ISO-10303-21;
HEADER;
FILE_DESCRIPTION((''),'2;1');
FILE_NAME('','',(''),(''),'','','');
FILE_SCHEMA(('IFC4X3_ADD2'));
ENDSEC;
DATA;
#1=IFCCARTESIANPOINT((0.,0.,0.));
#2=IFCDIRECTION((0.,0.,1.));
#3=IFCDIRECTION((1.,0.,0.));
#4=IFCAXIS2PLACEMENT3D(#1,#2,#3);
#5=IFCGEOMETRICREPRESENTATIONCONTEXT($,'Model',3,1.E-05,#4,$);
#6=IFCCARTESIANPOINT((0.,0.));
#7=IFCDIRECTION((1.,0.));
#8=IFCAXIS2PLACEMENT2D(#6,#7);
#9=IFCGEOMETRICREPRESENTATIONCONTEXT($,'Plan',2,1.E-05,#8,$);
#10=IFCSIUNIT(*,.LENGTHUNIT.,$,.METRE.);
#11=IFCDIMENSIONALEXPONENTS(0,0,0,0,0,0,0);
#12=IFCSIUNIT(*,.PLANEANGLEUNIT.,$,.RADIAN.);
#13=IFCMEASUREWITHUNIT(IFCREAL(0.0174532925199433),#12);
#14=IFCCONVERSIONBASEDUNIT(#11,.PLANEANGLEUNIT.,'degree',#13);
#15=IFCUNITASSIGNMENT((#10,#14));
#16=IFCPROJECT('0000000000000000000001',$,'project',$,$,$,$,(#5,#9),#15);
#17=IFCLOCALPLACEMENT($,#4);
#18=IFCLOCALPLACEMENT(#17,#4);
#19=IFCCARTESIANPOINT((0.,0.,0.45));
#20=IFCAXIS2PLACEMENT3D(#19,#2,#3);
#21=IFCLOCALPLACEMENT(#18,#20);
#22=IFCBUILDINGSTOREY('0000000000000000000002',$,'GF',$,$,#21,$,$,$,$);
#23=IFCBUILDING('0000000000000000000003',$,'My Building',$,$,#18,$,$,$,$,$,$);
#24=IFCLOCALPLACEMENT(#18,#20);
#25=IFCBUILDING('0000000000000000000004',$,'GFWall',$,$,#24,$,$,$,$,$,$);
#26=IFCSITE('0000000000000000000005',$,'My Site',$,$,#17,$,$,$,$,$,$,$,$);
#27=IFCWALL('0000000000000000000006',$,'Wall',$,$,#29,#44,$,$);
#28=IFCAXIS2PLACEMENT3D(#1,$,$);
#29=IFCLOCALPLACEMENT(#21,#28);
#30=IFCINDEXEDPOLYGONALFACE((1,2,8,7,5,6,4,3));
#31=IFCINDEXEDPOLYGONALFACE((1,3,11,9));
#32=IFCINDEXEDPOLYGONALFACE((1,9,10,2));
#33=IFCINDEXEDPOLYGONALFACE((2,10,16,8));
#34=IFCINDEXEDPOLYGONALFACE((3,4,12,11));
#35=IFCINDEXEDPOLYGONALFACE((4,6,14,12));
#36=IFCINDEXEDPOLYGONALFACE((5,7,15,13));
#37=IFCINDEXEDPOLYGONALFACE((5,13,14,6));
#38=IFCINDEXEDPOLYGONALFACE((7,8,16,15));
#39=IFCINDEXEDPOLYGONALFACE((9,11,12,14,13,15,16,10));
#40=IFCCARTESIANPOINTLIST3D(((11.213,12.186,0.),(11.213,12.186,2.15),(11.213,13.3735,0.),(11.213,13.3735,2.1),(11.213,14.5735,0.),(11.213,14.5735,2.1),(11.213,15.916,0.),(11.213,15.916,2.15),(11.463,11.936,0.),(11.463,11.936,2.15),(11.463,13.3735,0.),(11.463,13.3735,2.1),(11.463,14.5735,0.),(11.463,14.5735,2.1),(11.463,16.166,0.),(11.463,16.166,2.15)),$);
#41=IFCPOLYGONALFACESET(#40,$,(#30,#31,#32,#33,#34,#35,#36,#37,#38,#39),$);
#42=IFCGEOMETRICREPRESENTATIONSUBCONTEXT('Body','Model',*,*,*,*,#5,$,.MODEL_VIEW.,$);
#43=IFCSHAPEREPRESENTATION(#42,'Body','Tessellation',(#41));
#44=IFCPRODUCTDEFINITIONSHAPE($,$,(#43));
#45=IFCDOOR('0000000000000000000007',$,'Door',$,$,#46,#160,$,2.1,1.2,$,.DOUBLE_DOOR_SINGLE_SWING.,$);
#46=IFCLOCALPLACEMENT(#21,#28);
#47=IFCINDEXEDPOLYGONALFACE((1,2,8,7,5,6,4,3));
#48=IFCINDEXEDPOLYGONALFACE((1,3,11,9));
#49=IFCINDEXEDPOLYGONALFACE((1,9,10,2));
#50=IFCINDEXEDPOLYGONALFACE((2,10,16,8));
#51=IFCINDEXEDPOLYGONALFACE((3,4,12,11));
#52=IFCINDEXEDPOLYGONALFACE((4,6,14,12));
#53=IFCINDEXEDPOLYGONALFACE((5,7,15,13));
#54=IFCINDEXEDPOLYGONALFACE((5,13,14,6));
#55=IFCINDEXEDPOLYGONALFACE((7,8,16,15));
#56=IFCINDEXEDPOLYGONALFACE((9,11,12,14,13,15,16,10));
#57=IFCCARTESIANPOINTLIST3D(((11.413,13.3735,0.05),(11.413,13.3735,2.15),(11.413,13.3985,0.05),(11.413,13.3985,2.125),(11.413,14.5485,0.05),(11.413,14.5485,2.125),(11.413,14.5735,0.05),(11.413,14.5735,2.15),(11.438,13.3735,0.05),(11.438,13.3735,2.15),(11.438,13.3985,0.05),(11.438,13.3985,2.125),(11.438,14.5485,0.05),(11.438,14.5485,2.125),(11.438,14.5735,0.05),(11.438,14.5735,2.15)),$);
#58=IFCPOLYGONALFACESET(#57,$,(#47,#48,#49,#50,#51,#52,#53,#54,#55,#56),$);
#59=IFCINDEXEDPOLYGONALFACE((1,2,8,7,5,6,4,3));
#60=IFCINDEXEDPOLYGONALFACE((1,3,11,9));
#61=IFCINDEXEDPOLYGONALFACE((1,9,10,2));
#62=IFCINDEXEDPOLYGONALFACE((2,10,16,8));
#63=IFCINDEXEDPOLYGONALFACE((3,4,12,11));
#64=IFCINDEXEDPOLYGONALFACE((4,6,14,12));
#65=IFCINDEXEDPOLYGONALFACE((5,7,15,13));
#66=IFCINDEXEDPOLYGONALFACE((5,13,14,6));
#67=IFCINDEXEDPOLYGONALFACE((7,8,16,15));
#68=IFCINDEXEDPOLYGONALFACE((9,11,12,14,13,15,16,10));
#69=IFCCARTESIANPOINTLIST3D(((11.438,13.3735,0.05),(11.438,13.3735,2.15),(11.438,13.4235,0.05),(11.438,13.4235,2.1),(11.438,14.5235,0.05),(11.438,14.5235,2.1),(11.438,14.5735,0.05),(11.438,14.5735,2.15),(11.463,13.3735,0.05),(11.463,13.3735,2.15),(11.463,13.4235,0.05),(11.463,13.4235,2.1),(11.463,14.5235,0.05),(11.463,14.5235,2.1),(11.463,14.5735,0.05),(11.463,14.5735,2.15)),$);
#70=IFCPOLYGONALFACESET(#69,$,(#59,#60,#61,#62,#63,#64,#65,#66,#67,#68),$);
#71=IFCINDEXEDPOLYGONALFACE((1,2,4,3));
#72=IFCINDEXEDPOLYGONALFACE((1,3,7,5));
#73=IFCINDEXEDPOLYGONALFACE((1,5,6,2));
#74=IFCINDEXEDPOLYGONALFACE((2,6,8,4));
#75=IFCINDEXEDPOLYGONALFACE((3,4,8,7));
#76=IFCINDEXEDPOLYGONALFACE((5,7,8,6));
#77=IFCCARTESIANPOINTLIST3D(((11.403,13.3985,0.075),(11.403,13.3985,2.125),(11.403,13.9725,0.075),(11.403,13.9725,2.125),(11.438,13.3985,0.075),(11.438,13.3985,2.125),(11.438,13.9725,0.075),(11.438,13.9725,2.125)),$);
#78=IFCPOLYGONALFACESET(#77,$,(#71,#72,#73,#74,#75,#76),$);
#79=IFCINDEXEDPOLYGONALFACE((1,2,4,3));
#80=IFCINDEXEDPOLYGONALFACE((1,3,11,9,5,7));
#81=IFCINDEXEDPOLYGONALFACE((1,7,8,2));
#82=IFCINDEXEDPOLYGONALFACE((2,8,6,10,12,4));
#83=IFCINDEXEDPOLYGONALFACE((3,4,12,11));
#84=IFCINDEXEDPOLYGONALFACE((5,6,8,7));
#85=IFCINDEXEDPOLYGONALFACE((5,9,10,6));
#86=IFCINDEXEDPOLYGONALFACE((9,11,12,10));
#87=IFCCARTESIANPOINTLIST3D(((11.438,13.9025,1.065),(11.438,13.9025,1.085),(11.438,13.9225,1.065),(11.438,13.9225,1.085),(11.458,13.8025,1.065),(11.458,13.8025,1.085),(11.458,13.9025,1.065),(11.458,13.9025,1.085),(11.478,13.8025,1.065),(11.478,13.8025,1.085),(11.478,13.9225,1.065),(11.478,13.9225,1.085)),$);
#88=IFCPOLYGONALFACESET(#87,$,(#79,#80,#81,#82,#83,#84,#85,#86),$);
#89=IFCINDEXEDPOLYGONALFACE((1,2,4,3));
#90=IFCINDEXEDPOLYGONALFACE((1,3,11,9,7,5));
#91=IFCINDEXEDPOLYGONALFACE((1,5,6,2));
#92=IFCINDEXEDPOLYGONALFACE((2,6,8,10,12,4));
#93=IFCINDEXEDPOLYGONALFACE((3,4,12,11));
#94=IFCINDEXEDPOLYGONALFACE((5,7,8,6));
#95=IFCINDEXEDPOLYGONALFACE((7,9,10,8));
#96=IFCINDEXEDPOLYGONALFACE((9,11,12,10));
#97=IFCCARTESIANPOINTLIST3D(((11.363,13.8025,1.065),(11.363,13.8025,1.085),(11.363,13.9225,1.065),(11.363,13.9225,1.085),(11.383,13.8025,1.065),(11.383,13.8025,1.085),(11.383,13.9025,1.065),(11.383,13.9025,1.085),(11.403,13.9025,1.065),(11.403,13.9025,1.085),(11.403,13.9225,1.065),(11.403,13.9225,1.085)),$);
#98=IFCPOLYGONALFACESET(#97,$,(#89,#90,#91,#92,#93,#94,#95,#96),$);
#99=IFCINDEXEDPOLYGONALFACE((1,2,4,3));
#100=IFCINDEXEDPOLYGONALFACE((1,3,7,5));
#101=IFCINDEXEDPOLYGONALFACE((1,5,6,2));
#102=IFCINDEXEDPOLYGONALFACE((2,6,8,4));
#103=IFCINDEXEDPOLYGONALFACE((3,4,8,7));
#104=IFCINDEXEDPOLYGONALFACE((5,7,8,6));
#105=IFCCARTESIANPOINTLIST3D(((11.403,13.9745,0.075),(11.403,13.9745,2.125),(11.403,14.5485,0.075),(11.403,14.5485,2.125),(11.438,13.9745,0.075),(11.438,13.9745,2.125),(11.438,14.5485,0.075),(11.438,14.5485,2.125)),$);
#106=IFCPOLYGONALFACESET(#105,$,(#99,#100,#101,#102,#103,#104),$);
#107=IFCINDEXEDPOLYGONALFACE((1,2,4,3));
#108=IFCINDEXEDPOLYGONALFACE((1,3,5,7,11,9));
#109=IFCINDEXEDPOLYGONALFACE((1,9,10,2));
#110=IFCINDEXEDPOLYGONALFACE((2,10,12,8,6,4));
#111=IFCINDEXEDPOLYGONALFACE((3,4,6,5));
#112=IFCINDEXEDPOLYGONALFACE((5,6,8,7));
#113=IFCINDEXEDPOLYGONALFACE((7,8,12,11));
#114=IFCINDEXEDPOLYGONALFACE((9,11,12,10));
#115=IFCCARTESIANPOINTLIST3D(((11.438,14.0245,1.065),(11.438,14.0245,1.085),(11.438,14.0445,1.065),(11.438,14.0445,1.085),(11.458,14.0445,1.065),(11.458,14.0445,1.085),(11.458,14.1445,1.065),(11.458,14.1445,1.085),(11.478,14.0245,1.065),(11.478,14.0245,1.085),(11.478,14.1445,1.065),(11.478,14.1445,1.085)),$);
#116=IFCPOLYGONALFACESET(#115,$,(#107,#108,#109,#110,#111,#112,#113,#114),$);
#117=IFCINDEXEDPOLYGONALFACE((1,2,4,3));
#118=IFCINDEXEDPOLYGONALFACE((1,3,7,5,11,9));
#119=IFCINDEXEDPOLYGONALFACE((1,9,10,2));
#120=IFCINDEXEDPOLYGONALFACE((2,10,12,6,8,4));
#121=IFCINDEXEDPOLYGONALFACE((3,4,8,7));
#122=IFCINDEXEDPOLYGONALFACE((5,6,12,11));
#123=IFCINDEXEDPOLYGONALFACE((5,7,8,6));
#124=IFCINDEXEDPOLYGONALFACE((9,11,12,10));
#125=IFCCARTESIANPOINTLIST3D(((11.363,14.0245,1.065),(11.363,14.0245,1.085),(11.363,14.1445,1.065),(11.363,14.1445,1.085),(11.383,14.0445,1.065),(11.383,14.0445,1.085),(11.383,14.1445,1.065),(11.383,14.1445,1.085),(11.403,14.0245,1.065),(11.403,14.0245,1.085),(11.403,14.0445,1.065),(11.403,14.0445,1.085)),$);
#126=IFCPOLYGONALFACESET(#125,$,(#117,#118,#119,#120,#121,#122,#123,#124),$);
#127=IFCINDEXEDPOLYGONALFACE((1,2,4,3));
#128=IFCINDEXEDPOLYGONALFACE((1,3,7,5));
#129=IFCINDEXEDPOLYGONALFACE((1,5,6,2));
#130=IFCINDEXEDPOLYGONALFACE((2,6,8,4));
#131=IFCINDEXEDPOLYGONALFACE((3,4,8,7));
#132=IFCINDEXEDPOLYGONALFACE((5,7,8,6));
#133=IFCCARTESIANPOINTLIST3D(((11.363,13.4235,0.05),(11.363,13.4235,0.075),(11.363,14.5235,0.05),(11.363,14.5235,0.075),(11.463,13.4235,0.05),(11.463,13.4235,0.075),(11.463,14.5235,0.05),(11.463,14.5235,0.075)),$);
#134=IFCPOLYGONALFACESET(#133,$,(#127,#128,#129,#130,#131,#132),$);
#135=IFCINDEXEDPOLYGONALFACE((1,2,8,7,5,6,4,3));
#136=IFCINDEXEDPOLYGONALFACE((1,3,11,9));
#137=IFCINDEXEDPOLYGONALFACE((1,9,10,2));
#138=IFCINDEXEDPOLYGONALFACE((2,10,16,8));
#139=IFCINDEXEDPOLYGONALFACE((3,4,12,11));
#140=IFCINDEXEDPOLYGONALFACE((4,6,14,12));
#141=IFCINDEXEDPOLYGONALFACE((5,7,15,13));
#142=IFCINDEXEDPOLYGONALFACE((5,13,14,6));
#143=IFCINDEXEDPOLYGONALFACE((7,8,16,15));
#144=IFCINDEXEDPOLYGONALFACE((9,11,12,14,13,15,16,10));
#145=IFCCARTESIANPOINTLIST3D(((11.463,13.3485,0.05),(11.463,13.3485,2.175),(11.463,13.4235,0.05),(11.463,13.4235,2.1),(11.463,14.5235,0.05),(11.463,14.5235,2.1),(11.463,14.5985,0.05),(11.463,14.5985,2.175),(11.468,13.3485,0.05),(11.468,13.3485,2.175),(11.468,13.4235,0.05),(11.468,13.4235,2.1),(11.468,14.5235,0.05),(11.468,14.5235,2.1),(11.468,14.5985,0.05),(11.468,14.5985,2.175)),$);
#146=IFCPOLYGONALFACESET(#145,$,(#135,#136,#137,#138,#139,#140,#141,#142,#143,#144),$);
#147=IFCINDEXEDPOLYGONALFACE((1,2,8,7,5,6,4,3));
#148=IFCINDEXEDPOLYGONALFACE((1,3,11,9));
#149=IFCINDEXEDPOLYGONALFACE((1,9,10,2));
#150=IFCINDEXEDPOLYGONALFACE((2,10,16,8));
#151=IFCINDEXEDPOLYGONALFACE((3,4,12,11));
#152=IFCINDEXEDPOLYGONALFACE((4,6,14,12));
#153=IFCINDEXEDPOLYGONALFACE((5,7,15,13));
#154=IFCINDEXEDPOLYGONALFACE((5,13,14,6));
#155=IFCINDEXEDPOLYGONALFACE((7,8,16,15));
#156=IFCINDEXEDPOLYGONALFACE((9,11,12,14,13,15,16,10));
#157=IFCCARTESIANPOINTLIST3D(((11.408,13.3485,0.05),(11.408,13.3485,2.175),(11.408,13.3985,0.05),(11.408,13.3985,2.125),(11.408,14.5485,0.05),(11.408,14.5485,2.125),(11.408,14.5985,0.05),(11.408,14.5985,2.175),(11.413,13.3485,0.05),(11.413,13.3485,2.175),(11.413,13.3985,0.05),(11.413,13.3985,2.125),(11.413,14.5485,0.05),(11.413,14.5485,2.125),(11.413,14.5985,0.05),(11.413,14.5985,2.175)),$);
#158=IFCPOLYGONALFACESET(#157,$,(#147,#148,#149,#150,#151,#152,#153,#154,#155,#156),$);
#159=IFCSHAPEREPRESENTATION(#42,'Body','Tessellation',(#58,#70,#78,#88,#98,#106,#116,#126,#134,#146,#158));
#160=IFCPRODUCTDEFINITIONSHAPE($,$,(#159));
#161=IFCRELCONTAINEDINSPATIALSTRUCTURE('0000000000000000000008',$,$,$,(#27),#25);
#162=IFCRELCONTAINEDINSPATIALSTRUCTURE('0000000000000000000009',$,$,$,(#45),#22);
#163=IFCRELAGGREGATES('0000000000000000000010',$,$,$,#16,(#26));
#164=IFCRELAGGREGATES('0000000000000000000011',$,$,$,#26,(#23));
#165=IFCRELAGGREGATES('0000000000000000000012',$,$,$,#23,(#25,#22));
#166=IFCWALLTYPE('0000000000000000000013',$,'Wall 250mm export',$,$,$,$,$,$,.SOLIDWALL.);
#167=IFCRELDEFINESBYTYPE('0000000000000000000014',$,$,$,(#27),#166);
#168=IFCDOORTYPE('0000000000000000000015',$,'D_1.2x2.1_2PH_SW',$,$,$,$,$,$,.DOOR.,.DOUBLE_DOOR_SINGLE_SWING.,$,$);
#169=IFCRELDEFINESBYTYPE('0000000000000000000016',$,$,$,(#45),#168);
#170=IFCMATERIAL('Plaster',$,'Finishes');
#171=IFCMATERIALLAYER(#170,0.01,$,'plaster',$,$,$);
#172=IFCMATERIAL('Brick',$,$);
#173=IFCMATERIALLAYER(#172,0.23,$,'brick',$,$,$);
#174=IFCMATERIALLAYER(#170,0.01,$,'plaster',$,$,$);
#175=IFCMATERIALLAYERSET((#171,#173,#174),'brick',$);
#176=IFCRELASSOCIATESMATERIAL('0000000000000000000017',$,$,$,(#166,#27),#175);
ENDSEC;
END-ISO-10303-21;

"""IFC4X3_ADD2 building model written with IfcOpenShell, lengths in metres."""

from ifc_helpers import new_model, entity, si_unit, converted_unit, frame, origin_with_axes, origin_2d_with_axis, place, context, subcontext, project, spatial, line, indexed_curve, outline, extrude, shape, source, transform, mapped, material, layer, layer_set, layer_usage, type_object, type_shapes, element, fill, save


model = new_model("IFC4X3_ADD2")

# Units and contexts
model_context = context("Model", 3, precision=1e-05, world=origin_with_axes())
plan_context = context("Plan", 2, precision=1e-05, world=origin_2d_with_axis())
body_context_1 = subcontext(model_context, "Body", "Model", "MODEL_VIEW")
body_context_2 = subcontext(plan_context, "Body", "Plan", "PLAN_VIEW")
ifc_project = project(units=[si_unit("LENGTHUNIT", "METRE"), converted_unit("PLANEANGLEUNIT", "degree", entity("IfcReal", 0.0174532925199433), si_unit("PLANEANGLEUNIT", "RADIAN"), dimensions=[0, 0, 0, 0, 0, 0, 0])], contexts=[model_context, plan_context])

# Site, buildings
site_placement = place(None, origin_with_axes())
site = spatial("IfcSite", under=ifc_project, at=site_placement, Name="My Site")
building_1_placement = place(site_placement, origin_with_axes())
building_1 = spatial("IfcBuilding", under=site, at=building_1_placement, Name="My Building")
building_2_placement = place(building_1_placement, frame((0.0, 0.0, 0.45), z_axis=(0.0, 0.0, 1.0), x_axis=(1.0, 0.0, 0.0)))
building_2 = spatial("IfcBuilding", under=building_1, at=building_2_placement, Name="GFWall")

# Shared definitions
ifc_material_1 = material(Name="Plaster", Category="Finishes")
ifc_layer_1 = layer(ifc_material_1, 0.01, Name="plaster")
ifc_material_2 = material(Name="Brick")
ifc_layer_2 = layer(ifc_material_2, 0.23, Name="brick")
ifc_layer_3 = layer(ifc_material_1, 0.01, Name="plaster")
ifc_layer_set = layer_set([ifc_layer_1, ifc_layer_2, ifc_layer_3], Name="brick")
wall_type = type_object("IfcWallType", Name="Wall 250mm export", PredefinedType="SOLIDWALL", material=ifc_layer_set)

# Shared definitions
storey_placement = place(building_1_placement, frame((0.0, 0.0, 0.45), z_axis=(0.0, 0.0, 1.0), x_axis=(1.0, 0.0, 0.0)))
storey = spatial("IfcBuildingStorey", under=building_1, at=storey_placement, Name="GF")

# Wall, opening, door
ifc_layer_usage_1 = layer_usage(ifc_layer_set, "AXIS2", "POSITIVE", 0.0)
wall_1_placement = place(building_2_placement, frame((11.463, 11.936, 0.0), z_axis=(0.0, 0.0, 1.0), x_axis=(0.0, 1.0, 0.0)))
wall_1 = element("IfcWall", 1, at=wall_1_placement, inside=building_2, type_object=wall_type, material=ifc_layer_usage_1, Name="Wall", context=body_context_1, shape_type="SweptSolid", body=[
    extrude(outline(indexed_curve([(0.0, 0.0), (0.25, 0.25), (3.98, 0.25), (4.23, 0.0)], segments=[line(1, 2, 3, 4, 1)])), origin_with_axes(), (0.0, 0.0, 1.0), 2.15),
])
shared_shape_1 = source(origin_with_axes(), body_context_1, "Body", "SweptSolid", [
    extrude(outline(indexed_curve([(0.0, 0.0), (1.2, 0.0), (1.2, 2.1), (0.0, 2.1)], segments=[line(1, 2, 3, 4, 1)])), frame((0.0, -0.6, 0.0), z_axis=(0.0, -1.0, 0.0), x_axis=(1.0, 0.0, 0.0)), (0.0, 0.0, -1.0), 1.2),
])
opening_1_placement = place(wall_1_placement, frame((1.4375, 0.0, 0.0), z_axis=(0.0, 0.0, 1.0), x_axis=(1.0, 0.0, 0.0)))
opening_1 = element("IfcOpeningElement", 2, at=opening_1_placement, cuts=wall_1, PredefinedType="OPENING", context=body_context_1, shape_type="MappedRepresentation", body=[
    mapped(shared_shape_1, transform((0.0, 0.0, 0.0), x_axis=(1.0, 0.0, 0.0), y_axis=(0.0, 1.0, 0.0), z_axis=(0.0, 0.0, 1.0), scale=1.0)),
])
door_type_1 = type_object("IfcDoorType", Name="D_1.2x2.1_2PH_SW", OperationType="DOUBLE_DOOR_SINGLE_SWING", PredefinedType="DOOR")
shared_shape_2 = source(origin_with_axes(), body_context_1, "Body", "SweptSolid", [
    extrude(outline(indexed_curve([(0.0, 0.0), (0.0, 2.1), (1.2, 2.1), (1.2, 0.0), (1.175, 0.0), (1.175, 2.075), (0.025, 2.075), (0.025, 0.0)], segments=[line(1, 2, 3, 4, 5, 6, 7, 8, 1)])), frame((0.0, 0.025, 0.0), z_axis=(0.0, -1.0, 0.0), x_axis=(1.0, 0.0, 0.0)), (0.0, 0.0, -1.0), 0.025),
    extrude(outline(indexed_curve([(0.0, 0.0), (0.0, 2.1), (1.2, 2.1), (1.2, 0.0), (1.15, 0.0), (1.15, 2.05), (0.05, 2.05), (0.05, 0.0)], segments=[line(1, 2, 3, 4, 5, 6, 7, 8, 1)])), frame((0.0, 0.0, 0.0), z_axis=(0.0, -1.0, 0.0), x_axis=(1.0, 0.0, 0.0)), (0.0, 0.0, -1.0), 0.025),
    extrude(outline(indexed_curve([(0.0, 0.0), (0.574, 0.0), (0.574, 0.035), (0.0, 0.035)], segments=[line(1, 2, 3, 4, 1)])), frame((0.025, 0.025, 0.025), z_axis=(0.0, 0.0, 1.0), x_axis=(1.0, 0.0, 0.0)), (0.0, 0.0, 1.0), 2.05),
    extrude(outline(indexed_curve([(0.0, 0.0), (0.0, -0.04), (-0.12, -0.04), (-0.12, -0.02), (-0.02, -0.02), (-0.02, 0.0)], segments=[line(1, 2, 3, 4, 5, 6, 1)])), frame((0.549, 0.025, 1.015), z_axis=(0.0, 0.0, 1.0), x_axis=(1.0, 0.0, 0.0)), (0.0, 0.0, 1.0), 0.02),
    extrude(outline(indexed_curve([(0.0, 0.0), (0.0, 0.04), (-0.12, 0.04), (-0.12, 0.02), (-0.02, 0.02), (-0.02, 0.0)], segments=[line(1, 2, 3, 4, 5, 6, 1)])), frame((0.549, 0.06, 1.015), z_axis=(0.0, 0.0, 1.0), x_axis=(1.0, 0.0, 0.0)), (0.0, 0.0, 1.0), 0.02),
    extrude(outline(indexed_curve([(0.0, 0.0), (-0.574, 0.0), (-0.574, 0.035), (0.0, 0.035)], segments=[line(1, 2, 3, 4, 1)])), frame((1.175, 0.025, 0.025), z_axis=(0.0, 0.0, 1.0), x_axis=(1.0, 0.0, 0.0)), (0.0, 0.0, 1.0), 2.05),
    extrude(outline(indexed_curve([(0.0, 0.0), (0.0, -0.04), (0.12, -0.04), (0.12, -0.02), (0.02, -0.02), (0.02, 0.0)], segments=[line(1, 2, 3, 4, 5, 6, 1)])), frame((0.651, 0.025, 1.015), z_axis=(0.0, 0.0, 1.0), x_axis=(1.0, 0.0, 0.0)), (0.0, 0.0, 1.0), 0.02),
    extrude(outline(indexed_curve([(0.0, 0.0), (0.0, 0.04), (0.12, 0.04), (0.12, 0.02), (0.02, 0.02), (0.02, 0.0)], segments=[line(1, 2, 3, 4, 5, 6, 1)])), frame((0.651, 0.06, 1.015), z_axis=(0.0, 0.0, 1.0), x_axis=(1.0, 0.0, 0.0)), (0.0, 0.0, 1.0), 0.02),
    extrude(outline(indexed_curve([(0.0, 0.0), (1.1, 0.0), (1.1, 0.1), (0.0, 0.1)], segments=[line(1, 2, 3, 4, 1)])), frame((0.05, 0.0, 0.0), z_axis=(0.0, 0.0, 1.0), x_axis=(1.0, 0.0, 0.0)), (0.0, 0.0, 1.0), 0.025),
    extrude(outline(indexed_curve([(0.0, 0.0), (0.0, 2.125), (1.25, 2.125), (1.25, 0.0), (1.175, 0.0), (1.175, 2.05), (0.075, 2.05), (0.075, 0.0)], segments=[line(1, 2, 3, 4, 5, 6, 7, 8, 1)])), frame((-0.025, -0.005, 0.0), z_axis=(0.0, -1.0, 0.0), x_axis=(1.0, 0.0, 0.0)), (0.0, 0.0, -1.0), 0.005),
    extrude(outline(indexed_curve([(0.0, 0.0), (0.0, 2.125), (1.25, 2.125), (1.25, 0.0), (1.2, 0.0), (1.2, 2.075), (0.05, 2.075), (0.05, 0.0)], segments=[line(1, 2, 3, 4, 5, 6, 7, 8, 1)])), frame((-0.025, 0.05, 0.0), z_axis=(0.0, -1.0, 0.0), x_axis=(1.0, 0.0, 0.0)), (0.0, 0.0, -1.0), 0.005),
])
shared_shape_3 = source(origin_with_axes(), body_context_2, "Body", "Curve2D", [
    entity("IfcIndexedPolyCurve", entity("IfcCartesianPointList2D", [[0.0, 0.0], [0.0, 0.05], [0.025, 0.05], [0.025, 0.025], [0.05, 0.025], [0.05, 0.0]]), [entity("IfcLineIndex", [1, 2, 3, 4, 5, 6, 1])]),
    entity("IfcIndexedPolyCurve", entity("IfcCartesianPointList2D", [[1.2, 0.0], [1.2, 0.05], [1.175, 0.05], [1.175, 0.025], [1.15, 0.025], [1.15, 0.0]]), [entity("IfcLineIndex", [1, 2, 3, 4, 5, 6, 1])]),
    entity("IfcTrimmedCurve", entity("IfcEllipse", entity("IfcAxis2Placement2D", entity("IfcCartesianPoint", [0.06, 0.05]), entity("IfcDirection", [1.0, 0.0])), 0.54, 0.575), [entity("IfcCartesianPoint", [0.6, 0.05])], [entity("IfcCartesianPoint", [0.06, 0.625])], True, "CARTESIAN"),
    entity("IfcIndexedPolyCurve", entity("IfcCartesianPointList2D", [[0.025, 0.05], [0.06, 0.05], [0.06, 0.625], [0.025, 0.625]]), [entity("IfcLineIndex", [1, 2, 3, 4, 1])]),
    entity("IfcTrimmedCurve", entity("IfcEllipse", entity("IfcAxis2Placement2D", entity("IfcCartesianPoint", [1.14, 0.05]), entity("IfcDirection", [1.0, 0.0])), 0.54, 0.575), [entity("IfcCartesianPoint", [1.14, 0.625])], [entity("IfcCartesianPoint", [0.6, 0.05])], True, "CARTESIAN"),
    entity("IfcIndexedPolyCurve", entity("IfcCartesianPointList2D", [[1.175, 0.05], [1.14, 0.05], [1.14, 0.625], [1.175, 0.625]]), [entity("IfcLineIndex", [1, 2, 3, 4, 1])]),
])
type_shapes(door_type_1, [shared_shape_2, shared_shape_3])
door_1_placement = place(opening_1_placement, frame((0.0, 0.0, 0.05), z_axis=(0.0, 0.0, 1.0), x_axis=(1.0, 0.0, 0.0)))
door_1 = element("IfcDoor", 3, at=door_1_placement, inside=storey, type_object=door_type_1, Name="Door", OperationType="DOUBLE_DOOR_SINGLE_SWING", OverallHeight=2.1, OverallWidth=1.2, shapes=[
    shape(body_context_1, "Body", "MappedRepresentation", [mapped(shared_shape_2, transform((0.0, 0.0, 0.0), x_axis=(1.0, 0.0, 0.0), y_axis=(0.0, 1.0, 0.0), z_axis=(0.0, 0.0, 1.0), scale=1.0))]),
    shape(body_context_2, "Body", "MappedRepresentation", [mapped(shared_shape_3, transform((0.0, 0.0, 0.0), x_axis=(1.0, 0.0, 0.0), y_axis=(0.0, 1.0, 0.0), z_axis=(0.0, 0.0, 1.0), scale=1.0))]),
])
fill(opening_1, door_1)

save(model, "model.ifc")
